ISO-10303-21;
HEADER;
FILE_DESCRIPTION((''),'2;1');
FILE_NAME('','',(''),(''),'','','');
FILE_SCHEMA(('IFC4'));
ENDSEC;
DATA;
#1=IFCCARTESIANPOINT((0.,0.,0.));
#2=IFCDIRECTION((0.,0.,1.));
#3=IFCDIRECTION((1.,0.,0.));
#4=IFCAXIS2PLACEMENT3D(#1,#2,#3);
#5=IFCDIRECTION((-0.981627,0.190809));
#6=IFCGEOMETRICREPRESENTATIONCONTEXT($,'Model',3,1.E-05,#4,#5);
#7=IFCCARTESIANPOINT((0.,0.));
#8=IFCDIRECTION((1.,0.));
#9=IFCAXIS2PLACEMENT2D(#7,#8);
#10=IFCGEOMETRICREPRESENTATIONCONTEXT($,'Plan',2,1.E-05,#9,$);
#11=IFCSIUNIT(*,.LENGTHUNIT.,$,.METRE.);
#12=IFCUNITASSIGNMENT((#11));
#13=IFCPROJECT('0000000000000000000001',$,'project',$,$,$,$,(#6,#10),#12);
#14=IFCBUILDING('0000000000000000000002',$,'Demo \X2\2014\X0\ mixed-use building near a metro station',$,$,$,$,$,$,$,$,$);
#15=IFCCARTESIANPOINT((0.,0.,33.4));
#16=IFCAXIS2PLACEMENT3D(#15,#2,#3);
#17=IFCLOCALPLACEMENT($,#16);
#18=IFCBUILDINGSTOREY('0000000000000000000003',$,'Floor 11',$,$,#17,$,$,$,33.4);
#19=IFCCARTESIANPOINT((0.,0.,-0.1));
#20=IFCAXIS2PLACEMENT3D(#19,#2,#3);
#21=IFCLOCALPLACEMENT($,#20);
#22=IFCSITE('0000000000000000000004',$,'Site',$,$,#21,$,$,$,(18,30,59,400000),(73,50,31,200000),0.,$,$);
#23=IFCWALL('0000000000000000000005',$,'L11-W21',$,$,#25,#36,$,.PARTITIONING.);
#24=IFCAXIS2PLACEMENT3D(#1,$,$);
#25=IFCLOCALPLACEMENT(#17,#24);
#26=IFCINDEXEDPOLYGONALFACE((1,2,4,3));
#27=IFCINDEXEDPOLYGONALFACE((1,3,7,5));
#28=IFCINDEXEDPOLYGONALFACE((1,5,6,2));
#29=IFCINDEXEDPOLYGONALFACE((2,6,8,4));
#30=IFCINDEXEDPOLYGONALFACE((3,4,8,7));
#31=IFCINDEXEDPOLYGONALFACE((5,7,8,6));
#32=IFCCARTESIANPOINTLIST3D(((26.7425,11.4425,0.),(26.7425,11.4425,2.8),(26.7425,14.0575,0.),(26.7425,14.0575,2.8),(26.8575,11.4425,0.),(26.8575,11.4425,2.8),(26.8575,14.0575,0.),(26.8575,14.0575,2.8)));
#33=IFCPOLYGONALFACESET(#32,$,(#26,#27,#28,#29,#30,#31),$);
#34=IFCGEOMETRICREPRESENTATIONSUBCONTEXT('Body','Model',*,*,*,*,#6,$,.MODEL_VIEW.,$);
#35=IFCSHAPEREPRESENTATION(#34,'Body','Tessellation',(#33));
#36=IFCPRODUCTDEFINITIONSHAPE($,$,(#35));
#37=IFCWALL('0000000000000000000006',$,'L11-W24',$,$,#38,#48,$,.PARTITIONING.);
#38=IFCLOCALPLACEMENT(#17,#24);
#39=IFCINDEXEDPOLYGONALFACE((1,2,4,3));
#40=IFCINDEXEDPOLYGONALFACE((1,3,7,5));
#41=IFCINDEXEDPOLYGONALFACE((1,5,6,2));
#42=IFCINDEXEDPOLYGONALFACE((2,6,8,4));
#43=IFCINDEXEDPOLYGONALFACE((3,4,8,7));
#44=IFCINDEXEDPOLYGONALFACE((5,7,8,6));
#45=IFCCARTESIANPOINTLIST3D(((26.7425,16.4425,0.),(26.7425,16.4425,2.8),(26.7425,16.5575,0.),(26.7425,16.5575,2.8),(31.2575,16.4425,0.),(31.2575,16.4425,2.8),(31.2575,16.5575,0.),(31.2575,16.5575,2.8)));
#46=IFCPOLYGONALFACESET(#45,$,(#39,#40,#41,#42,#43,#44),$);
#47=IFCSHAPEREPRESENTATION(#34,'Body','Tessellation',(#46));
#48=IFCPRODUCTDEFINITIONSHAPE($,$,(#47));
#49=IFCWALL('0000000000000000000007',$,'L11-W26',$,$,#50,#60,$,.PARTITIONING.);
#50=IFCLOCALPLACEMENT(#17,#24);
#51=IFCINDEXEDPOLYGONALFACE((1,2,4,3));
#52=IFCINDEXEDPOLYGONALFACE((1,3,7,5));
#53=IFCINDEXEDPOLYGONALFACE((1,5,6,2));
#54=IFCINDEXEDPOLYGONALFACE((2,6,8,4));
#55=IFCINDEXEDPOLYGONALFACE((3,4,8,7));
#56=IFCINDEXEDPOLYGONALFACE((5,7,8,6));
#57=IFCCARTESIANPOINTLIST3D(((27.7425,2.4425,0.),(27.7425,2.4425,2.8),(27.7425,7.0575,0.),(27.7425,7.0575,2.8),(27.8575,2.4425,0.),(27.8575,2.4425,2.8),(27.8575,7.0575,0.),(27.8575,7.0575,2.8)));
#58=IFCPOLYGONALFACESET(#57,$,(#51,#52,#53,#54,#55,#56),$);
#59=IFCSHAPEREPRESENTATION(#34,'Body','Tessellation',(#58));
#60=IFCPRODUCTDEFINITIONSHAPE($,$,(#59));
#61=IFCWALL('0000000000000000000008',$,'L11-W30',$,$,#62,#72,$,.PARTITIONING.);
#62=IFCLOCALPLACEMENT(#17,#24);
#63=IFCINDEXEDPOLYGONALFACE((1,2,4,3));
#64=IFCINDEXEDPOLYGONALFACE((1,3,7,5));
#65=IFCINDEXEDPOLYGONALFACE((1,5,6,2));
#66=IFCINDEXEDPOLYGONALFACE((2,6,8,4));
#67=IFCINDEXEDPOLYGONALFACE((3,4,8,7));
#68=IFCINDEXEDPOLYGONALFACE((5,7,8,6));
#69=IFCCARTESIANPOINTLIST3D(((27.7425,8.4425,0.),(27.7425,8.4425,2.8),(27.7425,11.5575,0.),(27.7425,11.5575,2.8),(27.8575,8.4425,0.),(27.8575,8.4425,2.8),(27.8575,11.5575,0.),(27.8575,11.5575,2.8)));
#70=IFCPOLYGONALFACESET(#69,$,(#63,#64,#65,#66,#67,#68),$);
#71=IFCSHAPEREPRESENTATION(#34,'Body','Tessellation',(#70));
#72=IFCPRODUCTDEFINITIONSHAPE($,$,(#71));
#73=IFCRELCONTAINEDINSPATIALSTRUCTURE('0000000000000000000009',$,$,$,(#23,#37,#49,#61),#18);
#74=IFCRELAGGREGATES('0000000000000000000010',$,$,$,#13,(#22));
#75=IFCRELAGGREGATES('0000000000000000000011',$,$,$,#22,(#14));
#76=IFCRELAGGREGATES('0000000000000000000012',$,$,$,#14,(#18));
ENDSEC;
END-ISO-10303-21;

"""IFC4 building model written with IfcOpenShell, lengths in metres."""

from ifc_helpers import new_model, si_unit, direction, frame, origin_with_axes, origin_2d_with_axis, place, context, subcontext, project, spatial, line, indexed_curve, outline, extrude, element, save


model = new_model("IFC4")

# Units and contexts
model_context = context("Model", 3, precision=1e-05, world=origin_with_axes(), true_north=direction((-0.981627, 0.190809)))
plan_context = context("Plan", 2, precision=1e-05, world=origin_2d_with_axis())
body_context = subcontext(model_context, "Body", "Model", "MODEL_VIEW")
ifc_project = project(units=[si_unit("LENGTHUNIT", "METRE")], contexts=[model_context, plan_context])

# Site, building, storey
site_placement = place(None, frame((0.0, 0.0, -0.1), z_axis=(0.0, 0.0, 1.0), x_axis=(1.0, 0.0, 0.0)))
site = spatial("IfcSite", under=ifc_project, at=site_placement, Name="Site", RefLatitude=(18, 30, 59, 400000), RefLongitude=(73, 50, 31, 200000), RefElevation=0.0)
building = spatial("IfcBuilding", under=site, Name="Demo — mixed-use building near a metro station")
storey_placement = place(None, frame((0.0, 0.0, 33.4), z_axis=(0.0, 0.0, 1.0), x_axis=(1.0, 0.0, 0.0)))
storey = spatial("IfcBuildingStorey", under=building, at=storey_placement, Name="Floor 11", Elevation=33.4)

# Wall
wall_1_placement = place(storey_placement, frame((0.0, 0.0, -33.4), z_axis=(0.0, 0.0, 1.0), x_axis=(1.0, 0.0, 0.0)))
element("IfcWall", 1, at=wall_1_placement, inside=storey, Name="L11-W21", PredefinedType="PARTITIONING", context=body_context, shape_type="SweptSolid", body=[
    extrude(outline(indexed_curve([(26.7425, 11.4425), (26.7425, 14.0575), (26.8575, 14.0575), (26.8575, 11.4425)], segments=[line(1, 2, 3, 4, 1)])), frame((0.0, 0.0, 33.4), z_axis=(0.0, 0.0, 1.0), x_axis=(1.0, 0.0, 0.0)), (0.0, 0.0, 1.0), 2.8),
])

# Wall
wall_2_placement = place(storey_placement, frame((0.0, 0.0, -33.4), z_axis=(0.0, 0.0, 1.0), x_axis=(1.0, 0.0, 0.0)))
element("IfcWall", 2, at=wall_2_placement, inside=storey, Name="L11-W24", PredefinedType="PARTITIONING", context=body_context, shape_type="SweptSolid", body=[
    extrude(outline(indexed_curve([(31.2575, 16.4425), (26.7425, 16.4425), (26.7425, 16.5575), (31.2575, 16.5575)], segments=[line(1, 2, 3, 4, 1)])), frame((0.0, 0.0, 33.4), z_axis=(0.0, 0.0, 1.0), x_axis=(1.0, 0.0, 0.0)), (0.0, 0.0, 1.0), 2.8),
])

# Wall
wall_3_placement = place(storey_placement, frame((0.0, 0.0, -33.4), z_axis=(0.0, 0.0, 1.0), x_axis=(1.0, 0.0, 0.0)))
element("IfcWall", 3, at=wall_3_placement, inside=storey, Name="L11-W26", PredefinedType="PARTITIONING", context=body_context, shape_type="SweptSolid", body=[
    extrude(outline(indexed_curve([(27.7425, 2.4425), (27.7425, 7.0575), (27.8575, 7.0575), (27.8575, 2.4425)], segments=[line(1, 2, 3, 4, 1)])), frame((0.0, 0.0, 33.4), z_axis=(0.0, 0.0, 1.0), x_axis=(1.0, 0.0, 0.0)), (0.0, 0.0, 1.0), 2.8),
])

# Wall
wall_4_placement = place(storey_placement, frame((0.0, 0.0, -33.4), z_axis=(0.0, 0.0, 1.0), x_axis=(1.0, 0.0, 0.0)))
element("IfcWall", 4, at=wall_4_placement, inside=storey, Name="L11-W30", PredefinedType="PARTITIONING", context=body_context, shape_type="SweptSolid", body=[
    extrude(outline(indexed_curve([(27.7425, 8.4425), (27.7425, 11.5575), (27.8575, 11.5575), (27.8575, 8.4425)], segments=[line(1, 2, 3, 4, 1)])), frame((0.0, 0.0, 33.4), z_axis=(0.0, 0.0, 1.0), x_axis=(1.0, 0.0, 0.0)), (0.0, 0.0, 1.0), 2.8),
])

save(model, "model.ifc")
